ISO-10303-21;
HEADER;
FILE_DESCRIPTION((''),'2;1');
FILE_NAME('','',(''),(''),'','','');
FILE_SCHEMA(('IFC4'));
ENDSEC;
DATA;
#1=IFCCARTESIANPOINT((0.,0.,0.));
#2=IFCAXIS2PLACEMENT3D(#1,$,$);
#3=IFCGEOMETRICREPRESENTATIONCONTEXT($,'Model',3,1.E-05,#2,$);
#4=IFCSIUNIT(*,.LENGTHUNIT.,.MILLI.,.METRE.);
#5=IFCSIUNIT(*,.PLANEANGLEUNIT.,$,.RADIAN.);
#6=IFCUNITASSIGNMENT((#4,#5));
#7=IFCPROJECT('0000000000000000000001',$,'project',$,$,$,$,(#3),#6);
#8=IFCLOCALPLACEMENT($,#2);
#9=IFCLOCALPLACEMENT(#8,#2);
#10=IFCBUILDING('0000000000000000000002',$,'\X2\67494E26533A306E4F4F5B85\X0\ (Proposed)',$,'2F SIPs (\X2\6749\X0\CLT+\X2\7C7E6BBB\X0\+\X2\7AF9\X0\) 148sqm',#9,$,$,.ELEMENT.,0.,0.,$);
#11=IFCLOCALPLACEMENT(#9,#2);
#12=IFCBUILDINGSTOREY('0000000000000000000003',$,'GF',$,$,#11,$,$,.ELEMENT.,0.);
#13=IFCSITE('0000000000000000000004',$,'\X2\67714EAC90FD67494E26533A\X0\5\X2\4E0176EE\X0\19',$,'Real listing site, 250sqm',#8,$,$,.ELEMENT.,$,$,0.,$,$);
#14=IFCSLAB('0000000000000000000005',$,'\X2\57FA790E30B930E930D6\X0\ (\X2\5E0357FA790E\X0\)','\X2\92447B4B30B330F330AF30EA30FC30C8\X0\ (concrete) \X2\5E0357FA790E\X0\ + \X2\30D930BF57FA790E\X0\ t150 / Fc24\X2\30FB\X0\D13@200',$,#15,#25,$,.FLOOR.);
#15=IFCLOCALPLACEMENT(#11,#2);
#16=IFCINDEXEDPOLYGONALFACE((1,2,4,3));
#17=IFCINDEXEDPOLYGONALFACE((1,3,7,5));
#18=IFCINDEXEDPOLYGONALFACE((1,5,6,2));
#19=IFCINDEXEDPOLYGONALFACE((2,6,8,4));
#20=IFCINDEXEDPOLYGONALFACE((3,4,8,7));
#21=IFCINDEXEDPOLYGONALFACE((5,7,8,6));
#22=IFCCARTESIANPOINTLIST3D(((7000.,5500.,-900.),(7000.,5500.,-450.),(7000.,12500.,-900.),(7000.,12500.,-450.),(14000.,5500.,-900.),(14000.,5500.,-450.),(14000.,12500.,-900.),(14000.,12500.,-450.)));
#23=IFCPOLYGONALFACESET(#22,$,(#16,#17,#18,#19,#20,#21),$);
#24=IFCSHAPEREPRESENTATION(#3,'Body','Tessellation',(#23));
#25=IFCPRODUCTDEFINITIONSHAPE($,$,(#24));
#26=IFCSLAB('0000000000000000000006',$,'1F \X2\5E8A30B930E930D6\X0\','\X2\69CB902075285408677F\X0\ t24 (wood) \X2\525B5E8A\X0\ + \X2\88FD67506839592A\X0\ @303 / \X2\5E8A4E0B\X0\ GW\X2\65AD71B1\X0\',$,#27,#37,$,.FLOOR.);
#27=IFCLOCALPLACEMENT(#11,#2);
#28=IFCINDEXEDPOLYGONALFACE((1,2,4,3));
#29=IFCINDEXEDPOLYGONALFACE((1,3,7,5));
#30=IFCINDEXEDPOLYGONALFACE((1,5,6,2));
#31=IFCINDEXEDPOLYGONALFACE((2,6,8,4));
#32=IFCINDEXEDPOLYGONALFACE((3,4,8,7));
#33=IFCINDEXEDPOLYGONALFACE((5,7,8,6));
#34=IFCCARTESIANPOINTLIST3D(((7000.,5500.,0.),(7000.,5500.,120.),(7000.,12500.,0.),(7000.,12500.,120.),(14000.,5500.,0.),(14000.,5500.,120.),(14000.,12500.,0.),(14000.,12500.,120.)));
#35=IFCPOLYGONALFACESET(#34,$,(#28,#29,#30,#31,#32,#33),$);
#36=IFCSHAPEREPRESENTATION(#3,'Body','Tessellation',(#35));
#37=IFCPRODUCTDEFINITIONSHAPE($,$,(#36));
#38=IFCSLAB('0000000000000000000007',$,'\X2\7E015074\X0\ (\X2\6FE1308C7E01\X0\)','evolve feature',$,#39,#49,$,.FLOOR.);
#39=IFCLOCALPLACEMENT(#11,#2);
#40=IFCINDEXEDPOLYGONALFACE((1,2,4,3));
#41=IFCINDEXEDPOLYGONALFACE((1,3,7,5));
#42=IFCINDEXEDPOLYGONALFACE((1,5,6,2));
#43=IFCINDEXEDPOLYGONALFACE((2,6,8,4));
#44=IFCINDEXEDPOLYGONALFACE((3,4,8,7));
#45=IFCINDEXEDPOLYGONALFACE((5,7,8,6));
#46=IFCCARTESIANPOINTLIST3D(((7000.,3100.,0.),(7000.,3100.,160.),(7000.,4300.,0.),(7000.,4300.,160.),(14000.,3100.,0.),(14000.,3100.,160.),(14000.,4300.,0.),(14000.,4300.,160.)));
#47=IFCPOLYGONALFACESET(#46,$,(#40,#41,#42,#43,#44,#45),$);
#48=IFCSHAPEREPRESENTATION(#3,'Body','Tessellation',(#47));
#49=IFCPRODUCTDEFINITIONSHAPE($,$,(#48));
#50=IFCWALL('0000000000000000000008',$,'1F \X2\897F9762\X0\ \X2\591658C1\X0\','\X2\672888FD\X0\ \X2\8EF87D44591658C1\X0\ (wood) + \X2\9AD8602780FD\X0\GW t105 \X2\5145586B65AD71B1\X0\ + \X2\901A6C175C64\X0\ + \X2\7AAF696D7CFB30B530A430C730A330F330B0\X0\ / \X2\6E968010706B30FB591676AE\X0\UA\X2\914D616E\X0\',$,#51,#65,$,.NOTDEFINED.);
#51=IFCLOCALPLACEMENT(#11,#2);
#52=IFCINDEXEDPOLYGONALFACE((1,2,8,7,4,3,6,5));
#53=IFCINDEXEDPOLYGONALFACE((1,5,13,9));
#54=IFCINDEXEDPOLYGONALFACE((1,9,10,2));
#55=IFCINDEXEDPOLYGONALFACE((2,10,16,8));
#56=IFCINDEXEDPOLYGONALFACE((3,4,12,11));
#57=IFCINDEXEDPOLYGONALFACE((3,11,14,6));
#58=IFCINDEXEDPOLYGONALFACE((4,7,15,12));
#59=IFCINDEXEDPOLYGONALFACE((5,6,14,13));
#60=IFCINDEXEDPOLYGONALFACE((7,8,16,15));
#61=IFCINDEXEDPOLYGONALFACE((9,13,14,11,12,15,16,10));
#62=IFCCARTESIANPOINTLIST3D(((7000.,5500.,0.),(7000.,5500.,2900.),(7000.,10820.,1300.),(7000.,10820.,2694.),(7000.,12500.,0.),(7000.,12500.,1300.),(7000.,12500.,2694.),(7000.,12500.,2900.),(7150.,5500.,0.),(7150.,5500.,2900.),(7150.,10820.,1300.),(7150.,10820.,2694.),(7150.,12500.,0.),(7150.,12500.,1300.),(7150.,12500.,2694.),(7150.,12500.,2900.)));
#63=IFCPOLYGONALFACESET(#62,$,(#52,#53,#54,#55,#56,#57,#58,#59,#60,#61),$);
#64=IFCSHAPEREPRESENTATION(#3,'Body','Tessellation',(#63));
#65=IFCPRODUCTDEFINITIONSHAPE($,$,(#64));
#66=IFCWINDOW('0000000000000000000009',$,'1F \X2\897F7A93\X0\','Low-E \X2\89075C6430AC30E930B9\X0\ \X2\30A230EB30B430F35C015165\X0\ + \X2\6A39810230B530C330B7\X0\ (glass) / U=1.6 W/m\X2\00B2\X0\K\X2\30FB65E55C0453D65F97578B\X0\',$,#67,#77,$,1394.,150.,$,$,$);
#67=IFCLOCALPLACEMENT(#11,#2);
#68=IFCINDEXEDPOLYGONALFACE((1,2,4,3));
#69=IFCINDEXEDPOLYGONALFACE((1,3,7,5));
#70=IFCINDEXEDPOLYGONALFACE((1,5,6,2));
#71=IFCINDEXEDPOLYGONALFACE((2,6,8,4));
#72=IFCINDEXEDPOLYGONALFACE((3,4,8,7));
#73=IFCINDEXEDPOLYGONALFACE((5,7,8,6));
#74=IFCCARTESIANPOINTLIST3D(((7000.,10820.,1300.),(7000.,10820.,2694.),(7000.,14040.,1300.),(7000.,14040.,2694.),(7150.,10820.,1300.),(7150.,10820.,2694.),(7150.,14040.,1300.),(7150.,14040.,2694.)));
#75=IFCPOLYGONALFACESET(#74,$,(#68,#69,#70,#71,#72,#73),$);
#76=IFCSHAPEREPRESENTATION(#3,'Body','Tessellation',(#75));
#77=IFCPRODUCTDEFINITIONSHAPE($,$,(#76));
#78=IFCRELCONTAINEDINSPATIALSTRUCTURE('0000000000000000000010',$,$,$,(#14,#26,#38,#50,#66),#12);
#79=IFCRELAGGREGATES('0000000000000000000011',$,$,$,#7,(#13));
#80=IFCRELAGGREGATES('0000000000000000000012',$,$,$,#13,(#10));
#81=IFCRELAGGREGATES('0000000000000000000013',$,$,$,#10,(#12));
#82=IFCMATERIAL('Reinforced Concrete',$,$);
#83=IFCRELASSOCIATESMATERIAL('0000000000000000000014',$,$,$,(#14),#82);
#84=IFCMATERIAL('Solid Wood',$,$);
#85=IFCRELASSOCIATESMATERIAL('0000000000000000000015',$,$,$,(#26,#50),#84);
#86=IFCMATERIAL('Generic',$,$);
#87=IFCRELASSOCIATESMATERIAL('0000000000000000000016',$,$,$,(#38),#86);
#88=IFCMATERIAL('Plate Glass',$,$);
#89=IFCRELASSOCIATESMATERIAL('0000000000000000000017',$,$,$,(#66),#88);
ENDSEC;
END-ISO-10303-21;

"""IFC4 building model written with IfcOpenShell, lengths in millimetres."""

from ifc_helpers import new_model, si_unit, frame, frame_2d, origin, place, context, project, spatial, rectangle, extrude, material, element, fill, save


model = new_model("IFC4")

# Units and contexts
model_context = context("Model", 3, precision=1e-05, world=origin())
ifc_project = project(units=[si_unit("LENGTHUNIT", "METRE", prefix="MILLI"), si_unit("PLANEANGLEUNIT", "RADIAN")], contexts=[model_context])

# Site, building, storey
site_placement = place(None, origin())
site = spatial("IfcSite", under=ifc_project, at=site_placement, Name="東京都杉並区5丁目19", ObjectType="Real listing site, 250sqm", CompositionType="ELEMENT", RefElevation=0.0)
building_placement = place(site_placement, origin())
building = spatial("IfcBuilding", under=site, at=building_placement, Name="杉並区の住宅 (Proposed)", ObjectType="2F SIPs (杉CLT+籾殻+竹) 148sqm", CompositionType="ELEMENT", ElevationOfRefHeight=0.0, ElevationOfTerrain=0.0)
storey_placement = place(building_placement, origin())
storey = spatial("IfcBuildingStorey", under=building, at=storey_placement, Name="GF", CompositionType="ELEMENT", Elevation=0.0)

# Slabs
ifc_material_1 = material(Name="Reinforced Concrete")
slab_1_placement = place(storey_placement, frame((3500.0, 2750.0, -450.0)))
element("IfcSlab", 1, at=slab_1_placement, inside=storey, material=ifc_material_1, Name="基礎スラブ (布基礎)", Description="鉄筋コンクリート (concrete) 布基礎 + ベタ基礎 t150 / Fc24・D13@200", PredefinedType="FLOOR", context=model_context, shape_type="SweptSolid", body=[
    extrude(rectangle(XDim=7000.0, YDim=7000.0, at=frame_2d((3500.0, 3500.0))), frame((3500.0, 2750.0, -450.0)), (0.0, 0.0, 1.0), 450.0),
])
ifc_material_2 = material(Name="Solid Wood")
slab_2_placement = place(storey_placement, frame((3500.0, 2750.0, 0.0)))
element("IfcSlab", 2, at=slab_2_placement, inside=storey, material=ifc_material_2, Name="1F 床スラブ", Description="構造用合板 t24 (wood) 剛床 + 製材根太 @303 / 床下 GW断熱", PredefinedType="FLOOR", context=model_context, shape_type="SweptSolid", body=[
    extrude(rectangle(XDim=7000.0, YDim=7000.0, at=frame_2d((3500.0, 3500.0))), frame((3500.0, 2750.0, 0.0)), (0.0, 0.0, 1.0), 120.0),
])
ifc_material_3 = material(Name="Generic")
slab_3_placement = place(storey_placement, frame((3500.0, 1550.0, 0.0)))
element("IfcSlab", 3, at=slab_3_placement, inside=storey, material=ifc_material_3, Name="縁側 (濡れ縁)", Description="evolve feature", PredefinedType="FLOOR", context=model_context, shape_type="SweptSolid", body=[
    extrude(rectangle(XDim=7000.0, YDim=1200.0, at=frame_2d((3500.0, 600.0))), frame((3500.0, 1550.0, 0.0)), (0.0, 0.0, 1.0), 160.0),
])

# Shared definitions
ifc_material_4 = material(Name="Plate Glass")

# Wall, opening, window
wall_1_placement = place(storey_placement, frame((3500.0, 2750.0, 0.0)))
wall_1 = element("IfcWall", 4, at=wall_1_placement, inside=storey, material=ifc_material_2, Name="1F 西面 外壁", Description="木製 軸組外壁 (wood) + 高性能GW t105 充填断熱 + 通気層 + 窯業系サイディング / 準耐火・外皮UA配慮", PredefinedType="NOTDEFINED", context=model_context, shape_type="SweptSolid", body=[
    extrude(rectangle(XDim=150.0, YDim=7000.0, at=frame_2d((75.0, 3500.0))), frame((3500.0, 2750.0, 0.0)), (0.0, 0.0, 1.0), 2900.0),
])
opening_1_placement = place(storey_placement, frame((3500.0, 5410.0, 650.0)))
opening_1 = element("IfcOpeningElement", 5, at=opening_1_placement, cuts=wall_1, PredefinedType="NOTDEFINED", context=model_context, shape_type="SweptSolid", body=[
    extrude(rectangle(XDim=150.0, YDim=3220.0, at=frame_2d((75.0, 1610.0))), frame((3500.0, 5410.0, 650.0)), (0.0, 0.0, 1.0), 1394.0),
])
window_1_placement = place(storey_placement, frame((3500.0, 5410.0, 650.0)))
window_1 = element("IfcWindow", 6, at=window_1_placement, inside=storey, material=ifc_material_4, Name="1F 西窓", Description="Low-E 複層ガラス アルゴン封入 + 樹脂サッシ (glass) / U=1.6 W/m²K・日射取得型", OverallHeight=1394.0, OverallWidth=150.0, context=model_context, shape_type="SweptSolid", body=[
    extrude(rectangle(XDim=150.0, YDim=3220.0, at=frame_2d((75.0, 1610.0))), frame((3500.0, 5410.0, 650.0)), (0.0, 0.0, 1.0), 1394.0),
])
fill(opening_1, window_1)

save(model, "model.ifc")
